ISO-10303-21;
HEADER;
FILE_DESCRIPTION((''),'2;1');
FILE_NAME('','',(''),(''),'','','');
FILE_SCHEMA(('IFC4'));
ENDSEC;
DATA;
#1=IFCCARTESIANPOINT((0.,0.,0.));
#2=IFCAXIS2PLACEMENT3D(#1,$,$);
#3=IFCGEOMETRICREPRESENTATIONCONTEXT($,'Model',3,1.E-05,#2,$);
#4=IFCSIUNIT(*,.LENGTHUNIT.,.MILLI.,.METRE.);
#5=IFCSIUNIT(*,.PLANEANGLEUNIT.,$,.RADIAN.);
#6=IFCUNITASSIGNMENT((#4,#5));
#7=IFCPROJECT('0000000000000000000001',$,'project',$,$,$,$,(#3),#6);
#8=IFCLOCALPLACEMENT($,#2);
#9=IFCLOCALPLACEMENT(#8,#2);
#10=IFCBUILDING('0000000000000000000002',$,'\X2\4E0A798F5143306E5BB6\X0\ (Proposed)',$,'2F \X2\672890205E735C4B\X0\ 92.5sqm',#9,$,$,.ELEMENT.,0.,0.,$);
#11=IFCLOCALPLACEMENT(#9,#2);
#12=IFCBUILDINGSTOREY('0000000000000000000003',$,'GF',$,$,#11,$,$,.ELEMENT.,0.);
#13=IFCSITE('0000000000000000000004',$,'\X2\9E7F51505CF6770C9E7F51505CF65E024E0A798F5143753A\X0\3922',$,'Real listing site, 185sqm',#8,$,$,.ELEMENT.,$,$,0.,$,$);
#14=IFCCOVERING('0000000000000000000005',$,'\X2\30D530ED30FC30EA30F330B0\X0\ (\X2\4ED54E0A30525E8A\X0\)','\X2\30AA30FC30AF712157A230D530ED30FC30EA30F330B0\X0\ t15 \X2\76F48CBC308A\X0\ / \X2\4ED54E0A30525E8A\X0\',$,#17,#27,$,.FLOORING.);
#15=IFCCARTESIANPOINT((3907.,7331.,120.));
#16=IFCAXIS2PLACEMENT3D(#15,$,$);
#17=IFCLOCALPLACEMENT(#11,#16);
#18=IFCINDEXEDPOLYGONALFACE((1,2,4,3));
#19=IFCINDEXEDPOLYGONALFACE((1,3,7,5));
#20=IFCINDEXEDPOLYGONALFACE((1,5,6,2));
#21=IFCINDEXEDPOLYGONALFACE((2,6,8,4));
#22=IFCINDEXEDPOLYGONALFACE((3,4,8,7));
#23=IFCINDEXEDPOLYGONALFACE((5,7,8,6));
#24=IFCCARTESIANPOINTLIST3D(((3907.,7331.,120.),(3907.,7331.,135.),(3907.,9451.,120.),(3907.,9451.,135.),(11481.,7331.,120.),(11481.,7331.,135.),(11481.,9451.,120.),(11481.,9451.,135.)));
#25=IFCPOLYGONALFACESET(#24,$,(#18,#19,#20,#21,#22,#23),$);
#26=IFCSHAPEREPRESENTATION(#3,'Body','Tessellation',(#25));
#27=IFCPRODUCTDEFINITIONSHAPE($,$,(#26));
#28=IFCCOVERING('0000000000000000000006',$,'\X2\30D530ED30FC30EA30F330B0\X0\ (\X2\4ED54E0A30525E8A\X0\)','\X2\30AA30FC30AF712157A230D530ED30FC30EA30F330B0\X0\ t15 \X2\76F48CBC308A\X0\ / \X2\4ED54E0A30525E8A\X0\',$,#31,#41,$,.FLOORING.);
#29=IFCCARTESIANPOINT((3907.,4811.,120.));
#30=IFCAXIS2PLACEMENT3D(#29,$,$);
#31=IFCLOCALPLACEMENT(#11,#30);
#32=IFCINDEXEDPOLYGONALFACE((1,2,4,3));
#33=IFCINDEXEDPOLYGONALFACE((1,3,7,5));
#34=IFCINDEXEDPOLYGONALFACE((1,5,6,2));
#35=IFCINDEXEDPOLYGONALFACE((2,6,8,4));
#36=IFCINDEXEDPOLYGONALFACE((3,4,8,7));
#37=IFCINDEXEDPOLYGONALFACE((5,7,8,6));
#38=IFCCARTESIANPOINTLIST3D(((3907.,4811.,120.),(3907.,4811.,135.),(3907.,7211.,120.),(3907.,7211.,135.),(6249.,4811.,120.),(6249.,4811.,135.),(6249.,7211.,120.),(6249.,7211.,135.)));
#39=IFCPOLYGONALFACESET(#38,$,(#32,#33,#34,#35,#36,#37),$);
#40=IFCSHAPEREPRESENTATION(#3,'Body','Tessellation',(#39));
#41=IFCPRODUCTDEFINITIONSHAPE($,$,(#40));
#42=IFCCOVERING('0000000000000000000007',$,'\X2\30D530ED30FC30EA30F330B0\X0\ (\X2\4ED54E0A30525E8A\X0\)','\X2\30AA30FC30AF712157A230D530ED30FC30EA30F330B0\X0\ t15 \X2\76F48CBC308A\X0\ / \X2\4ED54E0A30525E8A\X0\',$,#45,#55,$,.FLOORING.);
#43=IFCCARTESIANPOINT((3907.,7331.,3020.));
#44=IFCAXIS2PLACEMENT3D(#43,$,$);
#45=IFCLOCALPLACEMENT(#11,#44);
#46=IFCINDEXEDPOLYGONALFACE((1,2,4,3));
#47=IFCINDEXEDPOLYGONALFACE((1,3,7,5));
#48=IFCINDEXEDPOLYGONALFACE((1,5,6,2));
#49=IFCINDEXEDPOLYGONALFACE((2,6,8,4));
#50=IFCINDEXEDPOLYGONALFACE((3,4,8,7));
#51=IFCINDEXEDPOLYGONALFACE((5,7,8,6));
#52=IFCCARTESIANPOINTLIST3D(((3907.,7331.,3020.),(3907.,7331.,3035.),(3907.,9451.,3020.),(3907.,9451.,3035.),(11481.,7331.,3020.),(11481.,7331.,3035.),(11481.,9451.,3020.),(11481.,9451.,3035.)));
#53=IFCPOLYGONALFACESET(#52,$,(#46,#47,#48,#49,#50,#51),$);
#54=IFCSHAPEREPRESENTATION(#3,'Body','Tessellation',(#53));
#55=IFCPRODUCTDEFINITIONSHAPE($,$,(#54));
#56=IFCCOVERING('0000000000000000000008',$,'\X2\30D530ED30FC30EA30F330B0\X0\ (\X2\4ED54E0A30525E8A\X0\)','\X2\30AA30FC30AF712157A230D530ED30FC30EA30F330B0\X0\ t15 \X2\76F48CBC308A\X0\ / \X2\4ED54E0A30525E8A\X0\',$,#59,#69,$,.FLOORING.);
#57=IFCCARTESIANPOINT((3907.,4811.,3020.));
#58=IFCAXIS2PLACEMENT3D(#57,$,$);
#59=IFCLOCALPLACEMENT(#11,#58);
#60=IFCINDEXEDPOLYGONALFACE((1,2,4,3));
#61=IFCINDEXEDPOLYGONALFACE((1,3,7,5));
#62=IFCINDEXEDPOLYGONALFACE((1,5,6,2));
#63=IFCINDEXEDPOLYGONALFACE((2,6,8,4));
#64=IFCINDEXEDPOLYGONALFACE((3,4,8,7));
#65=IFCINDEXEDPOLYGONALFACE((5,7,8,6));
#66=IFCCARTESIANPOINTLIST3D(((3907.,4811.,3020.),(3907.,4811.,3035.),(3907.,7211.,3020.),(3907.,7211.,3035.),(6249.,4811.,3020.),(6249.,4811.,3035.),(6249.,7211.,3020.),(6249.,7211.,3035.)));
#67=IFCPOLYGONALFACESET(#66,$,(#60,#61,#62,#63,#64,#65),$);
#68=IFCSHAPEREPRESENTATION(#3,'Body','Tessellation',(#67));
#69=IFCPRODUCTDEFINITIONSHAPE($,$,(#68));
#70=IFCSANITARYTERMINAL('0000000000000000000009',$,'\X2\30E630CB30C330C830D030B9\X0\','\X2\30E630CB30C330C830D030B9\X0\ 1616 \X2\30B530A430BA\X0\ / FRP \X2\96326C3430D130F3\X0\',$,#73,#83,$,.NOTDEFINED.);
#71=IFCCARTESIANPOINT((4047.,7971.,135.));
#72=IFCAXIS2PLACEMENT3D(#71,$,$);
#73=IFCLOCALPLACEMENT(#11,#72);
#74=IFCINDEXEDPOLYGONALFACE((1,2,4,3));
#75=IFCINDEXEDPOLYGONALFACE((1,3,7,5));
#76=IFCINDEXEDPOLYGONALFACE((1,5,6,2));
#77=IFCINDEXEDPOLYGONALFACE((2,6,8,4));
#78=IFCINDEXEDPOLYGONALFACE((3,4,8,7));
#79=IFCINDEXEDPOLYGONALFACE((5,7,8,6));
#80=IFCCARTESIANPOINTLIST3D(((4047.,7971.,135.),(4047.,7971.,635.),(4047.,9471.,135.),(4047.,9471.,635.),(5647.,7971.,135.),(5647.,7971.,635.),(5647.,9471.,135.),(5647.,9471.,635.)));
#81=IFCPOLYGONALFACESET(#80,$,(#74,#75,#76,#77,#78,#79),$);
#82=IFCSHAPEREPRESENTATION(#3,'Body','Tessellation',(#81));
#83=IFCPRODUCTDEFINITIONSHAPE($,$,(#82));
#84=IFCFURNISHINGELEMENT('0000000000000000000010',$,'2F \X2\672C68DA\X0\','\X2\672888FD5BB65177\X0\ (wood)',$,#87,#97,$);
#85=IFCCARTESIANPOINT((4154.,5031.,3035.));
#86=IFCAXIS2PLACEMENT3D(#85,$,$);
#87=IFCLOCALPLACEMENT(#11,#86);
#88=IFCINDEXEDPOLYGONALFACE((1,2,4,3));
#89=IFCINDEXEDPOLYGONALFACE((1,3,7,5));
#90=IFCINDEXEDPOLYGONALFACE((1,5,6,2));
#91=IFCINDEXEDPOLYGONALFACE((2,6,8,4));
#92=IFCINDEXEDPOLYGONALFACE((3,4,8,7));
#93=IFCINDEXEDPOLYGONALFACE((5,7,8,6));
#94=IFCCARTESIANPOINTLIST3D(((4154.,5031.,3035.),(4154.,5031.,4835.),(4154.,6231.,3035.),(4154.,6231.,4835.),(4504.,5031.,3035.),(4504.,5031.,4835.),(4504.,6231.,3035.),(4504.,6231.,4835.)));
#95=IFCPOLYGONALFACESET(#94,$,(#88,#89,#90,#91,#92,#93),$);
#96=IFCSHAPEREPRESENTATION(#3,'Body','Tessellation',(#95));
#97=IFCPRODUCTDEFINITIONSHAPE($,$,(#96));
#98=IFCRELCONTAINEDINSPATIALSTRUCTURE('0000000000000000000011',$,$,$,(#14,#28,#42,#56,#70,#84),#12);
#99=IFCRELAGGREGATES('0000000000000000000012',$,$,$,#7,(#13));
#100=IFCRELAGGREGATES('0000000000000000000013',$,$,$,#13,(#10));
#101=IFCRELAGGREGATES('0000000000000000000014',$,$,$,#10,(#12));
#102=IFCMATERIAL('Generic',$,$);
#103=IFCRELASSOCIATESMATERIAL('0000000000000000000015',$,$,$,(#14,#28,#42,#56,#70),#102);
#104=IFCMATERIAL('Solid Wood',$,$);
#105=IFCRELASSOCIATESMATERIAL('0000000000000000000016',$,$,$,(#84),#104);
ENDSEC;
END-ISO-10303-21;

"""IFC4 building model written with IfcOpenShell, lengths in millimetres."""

from ifc_helpers import new_model, si_unit, frame, frame_2d, origin, place, context, project, spatial, rectangle, extrude, material, element, save


model = new_model("IFC4")

# Units and contexts
model_context = context("Model", 3, precision=1e-05, world=origin())
ifc_project = project(units=[si_unit("LENGTHUNIT", "METRE", prefix="MILLI"), si_unit("PLANEANGLEUNIT", "RADIAN")], contexts=[model_context])

# Site, building, storey
site_placement = place(None, origin())
site = spatial("IfcSite", under=ifc_project, at=site_placement, Name="鹿児島県鹿児島市上福元町3922", ObjectType="Real listing site, 185sqm", CompositionType="ELEMENT", RefElevation=0.0)
building_placement = place(site_placement, origin())
building = spatial("IfcBuilding", under=site, at=building_placement, Name="上福元の家 (Proposed)", ObjectType="2F 木造平屋 92.5sqm", CompositionType="ELEMENT", ElevationOfRefHeight=0.0, ElevationOfTerrain=0.0)
storey_placement = place(building_placement, origin())
storey = spatial("IfcBuildingStorey", under=building, at=storey_placement, Name="GF", CompositionType="ELEMENT", Elevation=0.0)

# Shared definitions
ifc_material_1 = material(Name="Solid Wood")

# Coverings
ifc_material_2 = material(Name="Generic")
covering_1_placement = place(storey_placement, frame((3907.0, 7331.0, 120.0)))
element("IfcCovering", 1, at=covering_1_placement, inside=storey, material=ifc_material_2, Name="フローリング (仕上げ床)", Description="オーク無垢フローリング t15 直貼り / 仕上げ床", PredefinedType="FLOORING", context=model_context, shape_type="SweptSolid", body=[
    extrude(rectangle(XDim=7574.0, YDim=2120.0, at=frame_2d((3787.0, 1060.0))), frame((3907.0, 7331.0, 120.0)), (0.0, 0.0, 1.0), 15.0),
])
covering_2_placement = place(storey_placement, frame((3907.0, 4811.0, 120.0)))
element("IfcCovering", 2, at=covering_2_placement, inside=storey, material=ifc_material_2, Name="フローリング (仕上げ床)", Description="オーク無垢フローリング t15 直貼り / 仕上げ床", PredefinedType="FLOORING", context=model_context, shape_type="SweptSolid", body=[
    extrude(rectangle(XDim=2342.0, YDim=2400.0, at=frame_2d((1171.0, 1200.0))), frame((3907.0, 4811.0, 120.0)), (0.0, 0.0, 1.0), 15.0),
])
covering_3_placement = place(storey_placement, frame((3907.0, 7331.0, 3020.0)))
element("IfcCovering", 3, at=covering_3_placement, inside=storey, material=ifc_material_2, Name="フローリング (仕上げ床)", Description="オーク無垢フローリング t15 直貼り / 仕上げ床", PredefinedType="FLOORING", context=model_context, shape_type="SweptSolid", body=[
    extrude(rectangle(XDim=7574.0, YDim=2120.0, at=frame_2d((3787.0, 1060.0))), frame((3907.0, 7331.0, 3020.0)), (0.0, 0.0, 1.0), 15.0),
])
covering_4_placement = place(storey_placement, frame((3907.0, 4811.0, 3020.0)))
element("IfcCovering", 4, at=covering_4_placement, inside=storey, material=ifc_material_2, Name="フローリング (仕上げ床)", Description="オーク無垢フローリング t15 直貼り / 仕上げ床", PredefinedType="FLOORING", context=model_context, shape_type="SweptSolid", body=[
    extrude(rectangle(XDim=2342.0, YDim=2400.0, at=frame_2d((1171.0, 1200.0))), frame((3907.0, 4811.0, 3020.0)), (0.0, 0.0, 1.0), 15.0),
])

# Sanitary terminal
sanitary_terminal_placement = place(storey_placement, frame((4047.0, 7971.0, 135.0)))
element("IfcSanitaryTerminal", 5, at=sanitary_terminal_placement, inside=storey, material=ifc_material_2, Name="ユニットバス", Description="ユニットバス 1616 サイズ / FRP 防水パン", PredefinedType="NOTDEFINED", context=model_context, shape_type="SweptSolid", body=[
    extrude(rectangle(XDim=1600.0, YDim=1500.0, at=frame_2d((800.0, 750.0))), frame((4047.0, 7971.0, 135.0)), (0.0, 0.0, 1.0), 500.0),
])

# Furnishing element
furnishing_placement = place(storey_placement, frame((4154.0, 5031.0, 3035.0)))
element("IfcFurnishingElement", 6, at=furnishing_placement, inside=storey, material=ifc_material_1, Name="2F 本棚", Description="木製家具 (wood)", context=model_context, shape_type="SweptSolid", body=[
    extrude(rectangle(XDim=350.0, YDim=1200.0, at=frame_2d((175.0, 600.0))), frame((4154.0, 5031.0, 3035.0)), (0.0, 0.0, 1.0), 1800.0),
])

save(model, "model.ifc")
